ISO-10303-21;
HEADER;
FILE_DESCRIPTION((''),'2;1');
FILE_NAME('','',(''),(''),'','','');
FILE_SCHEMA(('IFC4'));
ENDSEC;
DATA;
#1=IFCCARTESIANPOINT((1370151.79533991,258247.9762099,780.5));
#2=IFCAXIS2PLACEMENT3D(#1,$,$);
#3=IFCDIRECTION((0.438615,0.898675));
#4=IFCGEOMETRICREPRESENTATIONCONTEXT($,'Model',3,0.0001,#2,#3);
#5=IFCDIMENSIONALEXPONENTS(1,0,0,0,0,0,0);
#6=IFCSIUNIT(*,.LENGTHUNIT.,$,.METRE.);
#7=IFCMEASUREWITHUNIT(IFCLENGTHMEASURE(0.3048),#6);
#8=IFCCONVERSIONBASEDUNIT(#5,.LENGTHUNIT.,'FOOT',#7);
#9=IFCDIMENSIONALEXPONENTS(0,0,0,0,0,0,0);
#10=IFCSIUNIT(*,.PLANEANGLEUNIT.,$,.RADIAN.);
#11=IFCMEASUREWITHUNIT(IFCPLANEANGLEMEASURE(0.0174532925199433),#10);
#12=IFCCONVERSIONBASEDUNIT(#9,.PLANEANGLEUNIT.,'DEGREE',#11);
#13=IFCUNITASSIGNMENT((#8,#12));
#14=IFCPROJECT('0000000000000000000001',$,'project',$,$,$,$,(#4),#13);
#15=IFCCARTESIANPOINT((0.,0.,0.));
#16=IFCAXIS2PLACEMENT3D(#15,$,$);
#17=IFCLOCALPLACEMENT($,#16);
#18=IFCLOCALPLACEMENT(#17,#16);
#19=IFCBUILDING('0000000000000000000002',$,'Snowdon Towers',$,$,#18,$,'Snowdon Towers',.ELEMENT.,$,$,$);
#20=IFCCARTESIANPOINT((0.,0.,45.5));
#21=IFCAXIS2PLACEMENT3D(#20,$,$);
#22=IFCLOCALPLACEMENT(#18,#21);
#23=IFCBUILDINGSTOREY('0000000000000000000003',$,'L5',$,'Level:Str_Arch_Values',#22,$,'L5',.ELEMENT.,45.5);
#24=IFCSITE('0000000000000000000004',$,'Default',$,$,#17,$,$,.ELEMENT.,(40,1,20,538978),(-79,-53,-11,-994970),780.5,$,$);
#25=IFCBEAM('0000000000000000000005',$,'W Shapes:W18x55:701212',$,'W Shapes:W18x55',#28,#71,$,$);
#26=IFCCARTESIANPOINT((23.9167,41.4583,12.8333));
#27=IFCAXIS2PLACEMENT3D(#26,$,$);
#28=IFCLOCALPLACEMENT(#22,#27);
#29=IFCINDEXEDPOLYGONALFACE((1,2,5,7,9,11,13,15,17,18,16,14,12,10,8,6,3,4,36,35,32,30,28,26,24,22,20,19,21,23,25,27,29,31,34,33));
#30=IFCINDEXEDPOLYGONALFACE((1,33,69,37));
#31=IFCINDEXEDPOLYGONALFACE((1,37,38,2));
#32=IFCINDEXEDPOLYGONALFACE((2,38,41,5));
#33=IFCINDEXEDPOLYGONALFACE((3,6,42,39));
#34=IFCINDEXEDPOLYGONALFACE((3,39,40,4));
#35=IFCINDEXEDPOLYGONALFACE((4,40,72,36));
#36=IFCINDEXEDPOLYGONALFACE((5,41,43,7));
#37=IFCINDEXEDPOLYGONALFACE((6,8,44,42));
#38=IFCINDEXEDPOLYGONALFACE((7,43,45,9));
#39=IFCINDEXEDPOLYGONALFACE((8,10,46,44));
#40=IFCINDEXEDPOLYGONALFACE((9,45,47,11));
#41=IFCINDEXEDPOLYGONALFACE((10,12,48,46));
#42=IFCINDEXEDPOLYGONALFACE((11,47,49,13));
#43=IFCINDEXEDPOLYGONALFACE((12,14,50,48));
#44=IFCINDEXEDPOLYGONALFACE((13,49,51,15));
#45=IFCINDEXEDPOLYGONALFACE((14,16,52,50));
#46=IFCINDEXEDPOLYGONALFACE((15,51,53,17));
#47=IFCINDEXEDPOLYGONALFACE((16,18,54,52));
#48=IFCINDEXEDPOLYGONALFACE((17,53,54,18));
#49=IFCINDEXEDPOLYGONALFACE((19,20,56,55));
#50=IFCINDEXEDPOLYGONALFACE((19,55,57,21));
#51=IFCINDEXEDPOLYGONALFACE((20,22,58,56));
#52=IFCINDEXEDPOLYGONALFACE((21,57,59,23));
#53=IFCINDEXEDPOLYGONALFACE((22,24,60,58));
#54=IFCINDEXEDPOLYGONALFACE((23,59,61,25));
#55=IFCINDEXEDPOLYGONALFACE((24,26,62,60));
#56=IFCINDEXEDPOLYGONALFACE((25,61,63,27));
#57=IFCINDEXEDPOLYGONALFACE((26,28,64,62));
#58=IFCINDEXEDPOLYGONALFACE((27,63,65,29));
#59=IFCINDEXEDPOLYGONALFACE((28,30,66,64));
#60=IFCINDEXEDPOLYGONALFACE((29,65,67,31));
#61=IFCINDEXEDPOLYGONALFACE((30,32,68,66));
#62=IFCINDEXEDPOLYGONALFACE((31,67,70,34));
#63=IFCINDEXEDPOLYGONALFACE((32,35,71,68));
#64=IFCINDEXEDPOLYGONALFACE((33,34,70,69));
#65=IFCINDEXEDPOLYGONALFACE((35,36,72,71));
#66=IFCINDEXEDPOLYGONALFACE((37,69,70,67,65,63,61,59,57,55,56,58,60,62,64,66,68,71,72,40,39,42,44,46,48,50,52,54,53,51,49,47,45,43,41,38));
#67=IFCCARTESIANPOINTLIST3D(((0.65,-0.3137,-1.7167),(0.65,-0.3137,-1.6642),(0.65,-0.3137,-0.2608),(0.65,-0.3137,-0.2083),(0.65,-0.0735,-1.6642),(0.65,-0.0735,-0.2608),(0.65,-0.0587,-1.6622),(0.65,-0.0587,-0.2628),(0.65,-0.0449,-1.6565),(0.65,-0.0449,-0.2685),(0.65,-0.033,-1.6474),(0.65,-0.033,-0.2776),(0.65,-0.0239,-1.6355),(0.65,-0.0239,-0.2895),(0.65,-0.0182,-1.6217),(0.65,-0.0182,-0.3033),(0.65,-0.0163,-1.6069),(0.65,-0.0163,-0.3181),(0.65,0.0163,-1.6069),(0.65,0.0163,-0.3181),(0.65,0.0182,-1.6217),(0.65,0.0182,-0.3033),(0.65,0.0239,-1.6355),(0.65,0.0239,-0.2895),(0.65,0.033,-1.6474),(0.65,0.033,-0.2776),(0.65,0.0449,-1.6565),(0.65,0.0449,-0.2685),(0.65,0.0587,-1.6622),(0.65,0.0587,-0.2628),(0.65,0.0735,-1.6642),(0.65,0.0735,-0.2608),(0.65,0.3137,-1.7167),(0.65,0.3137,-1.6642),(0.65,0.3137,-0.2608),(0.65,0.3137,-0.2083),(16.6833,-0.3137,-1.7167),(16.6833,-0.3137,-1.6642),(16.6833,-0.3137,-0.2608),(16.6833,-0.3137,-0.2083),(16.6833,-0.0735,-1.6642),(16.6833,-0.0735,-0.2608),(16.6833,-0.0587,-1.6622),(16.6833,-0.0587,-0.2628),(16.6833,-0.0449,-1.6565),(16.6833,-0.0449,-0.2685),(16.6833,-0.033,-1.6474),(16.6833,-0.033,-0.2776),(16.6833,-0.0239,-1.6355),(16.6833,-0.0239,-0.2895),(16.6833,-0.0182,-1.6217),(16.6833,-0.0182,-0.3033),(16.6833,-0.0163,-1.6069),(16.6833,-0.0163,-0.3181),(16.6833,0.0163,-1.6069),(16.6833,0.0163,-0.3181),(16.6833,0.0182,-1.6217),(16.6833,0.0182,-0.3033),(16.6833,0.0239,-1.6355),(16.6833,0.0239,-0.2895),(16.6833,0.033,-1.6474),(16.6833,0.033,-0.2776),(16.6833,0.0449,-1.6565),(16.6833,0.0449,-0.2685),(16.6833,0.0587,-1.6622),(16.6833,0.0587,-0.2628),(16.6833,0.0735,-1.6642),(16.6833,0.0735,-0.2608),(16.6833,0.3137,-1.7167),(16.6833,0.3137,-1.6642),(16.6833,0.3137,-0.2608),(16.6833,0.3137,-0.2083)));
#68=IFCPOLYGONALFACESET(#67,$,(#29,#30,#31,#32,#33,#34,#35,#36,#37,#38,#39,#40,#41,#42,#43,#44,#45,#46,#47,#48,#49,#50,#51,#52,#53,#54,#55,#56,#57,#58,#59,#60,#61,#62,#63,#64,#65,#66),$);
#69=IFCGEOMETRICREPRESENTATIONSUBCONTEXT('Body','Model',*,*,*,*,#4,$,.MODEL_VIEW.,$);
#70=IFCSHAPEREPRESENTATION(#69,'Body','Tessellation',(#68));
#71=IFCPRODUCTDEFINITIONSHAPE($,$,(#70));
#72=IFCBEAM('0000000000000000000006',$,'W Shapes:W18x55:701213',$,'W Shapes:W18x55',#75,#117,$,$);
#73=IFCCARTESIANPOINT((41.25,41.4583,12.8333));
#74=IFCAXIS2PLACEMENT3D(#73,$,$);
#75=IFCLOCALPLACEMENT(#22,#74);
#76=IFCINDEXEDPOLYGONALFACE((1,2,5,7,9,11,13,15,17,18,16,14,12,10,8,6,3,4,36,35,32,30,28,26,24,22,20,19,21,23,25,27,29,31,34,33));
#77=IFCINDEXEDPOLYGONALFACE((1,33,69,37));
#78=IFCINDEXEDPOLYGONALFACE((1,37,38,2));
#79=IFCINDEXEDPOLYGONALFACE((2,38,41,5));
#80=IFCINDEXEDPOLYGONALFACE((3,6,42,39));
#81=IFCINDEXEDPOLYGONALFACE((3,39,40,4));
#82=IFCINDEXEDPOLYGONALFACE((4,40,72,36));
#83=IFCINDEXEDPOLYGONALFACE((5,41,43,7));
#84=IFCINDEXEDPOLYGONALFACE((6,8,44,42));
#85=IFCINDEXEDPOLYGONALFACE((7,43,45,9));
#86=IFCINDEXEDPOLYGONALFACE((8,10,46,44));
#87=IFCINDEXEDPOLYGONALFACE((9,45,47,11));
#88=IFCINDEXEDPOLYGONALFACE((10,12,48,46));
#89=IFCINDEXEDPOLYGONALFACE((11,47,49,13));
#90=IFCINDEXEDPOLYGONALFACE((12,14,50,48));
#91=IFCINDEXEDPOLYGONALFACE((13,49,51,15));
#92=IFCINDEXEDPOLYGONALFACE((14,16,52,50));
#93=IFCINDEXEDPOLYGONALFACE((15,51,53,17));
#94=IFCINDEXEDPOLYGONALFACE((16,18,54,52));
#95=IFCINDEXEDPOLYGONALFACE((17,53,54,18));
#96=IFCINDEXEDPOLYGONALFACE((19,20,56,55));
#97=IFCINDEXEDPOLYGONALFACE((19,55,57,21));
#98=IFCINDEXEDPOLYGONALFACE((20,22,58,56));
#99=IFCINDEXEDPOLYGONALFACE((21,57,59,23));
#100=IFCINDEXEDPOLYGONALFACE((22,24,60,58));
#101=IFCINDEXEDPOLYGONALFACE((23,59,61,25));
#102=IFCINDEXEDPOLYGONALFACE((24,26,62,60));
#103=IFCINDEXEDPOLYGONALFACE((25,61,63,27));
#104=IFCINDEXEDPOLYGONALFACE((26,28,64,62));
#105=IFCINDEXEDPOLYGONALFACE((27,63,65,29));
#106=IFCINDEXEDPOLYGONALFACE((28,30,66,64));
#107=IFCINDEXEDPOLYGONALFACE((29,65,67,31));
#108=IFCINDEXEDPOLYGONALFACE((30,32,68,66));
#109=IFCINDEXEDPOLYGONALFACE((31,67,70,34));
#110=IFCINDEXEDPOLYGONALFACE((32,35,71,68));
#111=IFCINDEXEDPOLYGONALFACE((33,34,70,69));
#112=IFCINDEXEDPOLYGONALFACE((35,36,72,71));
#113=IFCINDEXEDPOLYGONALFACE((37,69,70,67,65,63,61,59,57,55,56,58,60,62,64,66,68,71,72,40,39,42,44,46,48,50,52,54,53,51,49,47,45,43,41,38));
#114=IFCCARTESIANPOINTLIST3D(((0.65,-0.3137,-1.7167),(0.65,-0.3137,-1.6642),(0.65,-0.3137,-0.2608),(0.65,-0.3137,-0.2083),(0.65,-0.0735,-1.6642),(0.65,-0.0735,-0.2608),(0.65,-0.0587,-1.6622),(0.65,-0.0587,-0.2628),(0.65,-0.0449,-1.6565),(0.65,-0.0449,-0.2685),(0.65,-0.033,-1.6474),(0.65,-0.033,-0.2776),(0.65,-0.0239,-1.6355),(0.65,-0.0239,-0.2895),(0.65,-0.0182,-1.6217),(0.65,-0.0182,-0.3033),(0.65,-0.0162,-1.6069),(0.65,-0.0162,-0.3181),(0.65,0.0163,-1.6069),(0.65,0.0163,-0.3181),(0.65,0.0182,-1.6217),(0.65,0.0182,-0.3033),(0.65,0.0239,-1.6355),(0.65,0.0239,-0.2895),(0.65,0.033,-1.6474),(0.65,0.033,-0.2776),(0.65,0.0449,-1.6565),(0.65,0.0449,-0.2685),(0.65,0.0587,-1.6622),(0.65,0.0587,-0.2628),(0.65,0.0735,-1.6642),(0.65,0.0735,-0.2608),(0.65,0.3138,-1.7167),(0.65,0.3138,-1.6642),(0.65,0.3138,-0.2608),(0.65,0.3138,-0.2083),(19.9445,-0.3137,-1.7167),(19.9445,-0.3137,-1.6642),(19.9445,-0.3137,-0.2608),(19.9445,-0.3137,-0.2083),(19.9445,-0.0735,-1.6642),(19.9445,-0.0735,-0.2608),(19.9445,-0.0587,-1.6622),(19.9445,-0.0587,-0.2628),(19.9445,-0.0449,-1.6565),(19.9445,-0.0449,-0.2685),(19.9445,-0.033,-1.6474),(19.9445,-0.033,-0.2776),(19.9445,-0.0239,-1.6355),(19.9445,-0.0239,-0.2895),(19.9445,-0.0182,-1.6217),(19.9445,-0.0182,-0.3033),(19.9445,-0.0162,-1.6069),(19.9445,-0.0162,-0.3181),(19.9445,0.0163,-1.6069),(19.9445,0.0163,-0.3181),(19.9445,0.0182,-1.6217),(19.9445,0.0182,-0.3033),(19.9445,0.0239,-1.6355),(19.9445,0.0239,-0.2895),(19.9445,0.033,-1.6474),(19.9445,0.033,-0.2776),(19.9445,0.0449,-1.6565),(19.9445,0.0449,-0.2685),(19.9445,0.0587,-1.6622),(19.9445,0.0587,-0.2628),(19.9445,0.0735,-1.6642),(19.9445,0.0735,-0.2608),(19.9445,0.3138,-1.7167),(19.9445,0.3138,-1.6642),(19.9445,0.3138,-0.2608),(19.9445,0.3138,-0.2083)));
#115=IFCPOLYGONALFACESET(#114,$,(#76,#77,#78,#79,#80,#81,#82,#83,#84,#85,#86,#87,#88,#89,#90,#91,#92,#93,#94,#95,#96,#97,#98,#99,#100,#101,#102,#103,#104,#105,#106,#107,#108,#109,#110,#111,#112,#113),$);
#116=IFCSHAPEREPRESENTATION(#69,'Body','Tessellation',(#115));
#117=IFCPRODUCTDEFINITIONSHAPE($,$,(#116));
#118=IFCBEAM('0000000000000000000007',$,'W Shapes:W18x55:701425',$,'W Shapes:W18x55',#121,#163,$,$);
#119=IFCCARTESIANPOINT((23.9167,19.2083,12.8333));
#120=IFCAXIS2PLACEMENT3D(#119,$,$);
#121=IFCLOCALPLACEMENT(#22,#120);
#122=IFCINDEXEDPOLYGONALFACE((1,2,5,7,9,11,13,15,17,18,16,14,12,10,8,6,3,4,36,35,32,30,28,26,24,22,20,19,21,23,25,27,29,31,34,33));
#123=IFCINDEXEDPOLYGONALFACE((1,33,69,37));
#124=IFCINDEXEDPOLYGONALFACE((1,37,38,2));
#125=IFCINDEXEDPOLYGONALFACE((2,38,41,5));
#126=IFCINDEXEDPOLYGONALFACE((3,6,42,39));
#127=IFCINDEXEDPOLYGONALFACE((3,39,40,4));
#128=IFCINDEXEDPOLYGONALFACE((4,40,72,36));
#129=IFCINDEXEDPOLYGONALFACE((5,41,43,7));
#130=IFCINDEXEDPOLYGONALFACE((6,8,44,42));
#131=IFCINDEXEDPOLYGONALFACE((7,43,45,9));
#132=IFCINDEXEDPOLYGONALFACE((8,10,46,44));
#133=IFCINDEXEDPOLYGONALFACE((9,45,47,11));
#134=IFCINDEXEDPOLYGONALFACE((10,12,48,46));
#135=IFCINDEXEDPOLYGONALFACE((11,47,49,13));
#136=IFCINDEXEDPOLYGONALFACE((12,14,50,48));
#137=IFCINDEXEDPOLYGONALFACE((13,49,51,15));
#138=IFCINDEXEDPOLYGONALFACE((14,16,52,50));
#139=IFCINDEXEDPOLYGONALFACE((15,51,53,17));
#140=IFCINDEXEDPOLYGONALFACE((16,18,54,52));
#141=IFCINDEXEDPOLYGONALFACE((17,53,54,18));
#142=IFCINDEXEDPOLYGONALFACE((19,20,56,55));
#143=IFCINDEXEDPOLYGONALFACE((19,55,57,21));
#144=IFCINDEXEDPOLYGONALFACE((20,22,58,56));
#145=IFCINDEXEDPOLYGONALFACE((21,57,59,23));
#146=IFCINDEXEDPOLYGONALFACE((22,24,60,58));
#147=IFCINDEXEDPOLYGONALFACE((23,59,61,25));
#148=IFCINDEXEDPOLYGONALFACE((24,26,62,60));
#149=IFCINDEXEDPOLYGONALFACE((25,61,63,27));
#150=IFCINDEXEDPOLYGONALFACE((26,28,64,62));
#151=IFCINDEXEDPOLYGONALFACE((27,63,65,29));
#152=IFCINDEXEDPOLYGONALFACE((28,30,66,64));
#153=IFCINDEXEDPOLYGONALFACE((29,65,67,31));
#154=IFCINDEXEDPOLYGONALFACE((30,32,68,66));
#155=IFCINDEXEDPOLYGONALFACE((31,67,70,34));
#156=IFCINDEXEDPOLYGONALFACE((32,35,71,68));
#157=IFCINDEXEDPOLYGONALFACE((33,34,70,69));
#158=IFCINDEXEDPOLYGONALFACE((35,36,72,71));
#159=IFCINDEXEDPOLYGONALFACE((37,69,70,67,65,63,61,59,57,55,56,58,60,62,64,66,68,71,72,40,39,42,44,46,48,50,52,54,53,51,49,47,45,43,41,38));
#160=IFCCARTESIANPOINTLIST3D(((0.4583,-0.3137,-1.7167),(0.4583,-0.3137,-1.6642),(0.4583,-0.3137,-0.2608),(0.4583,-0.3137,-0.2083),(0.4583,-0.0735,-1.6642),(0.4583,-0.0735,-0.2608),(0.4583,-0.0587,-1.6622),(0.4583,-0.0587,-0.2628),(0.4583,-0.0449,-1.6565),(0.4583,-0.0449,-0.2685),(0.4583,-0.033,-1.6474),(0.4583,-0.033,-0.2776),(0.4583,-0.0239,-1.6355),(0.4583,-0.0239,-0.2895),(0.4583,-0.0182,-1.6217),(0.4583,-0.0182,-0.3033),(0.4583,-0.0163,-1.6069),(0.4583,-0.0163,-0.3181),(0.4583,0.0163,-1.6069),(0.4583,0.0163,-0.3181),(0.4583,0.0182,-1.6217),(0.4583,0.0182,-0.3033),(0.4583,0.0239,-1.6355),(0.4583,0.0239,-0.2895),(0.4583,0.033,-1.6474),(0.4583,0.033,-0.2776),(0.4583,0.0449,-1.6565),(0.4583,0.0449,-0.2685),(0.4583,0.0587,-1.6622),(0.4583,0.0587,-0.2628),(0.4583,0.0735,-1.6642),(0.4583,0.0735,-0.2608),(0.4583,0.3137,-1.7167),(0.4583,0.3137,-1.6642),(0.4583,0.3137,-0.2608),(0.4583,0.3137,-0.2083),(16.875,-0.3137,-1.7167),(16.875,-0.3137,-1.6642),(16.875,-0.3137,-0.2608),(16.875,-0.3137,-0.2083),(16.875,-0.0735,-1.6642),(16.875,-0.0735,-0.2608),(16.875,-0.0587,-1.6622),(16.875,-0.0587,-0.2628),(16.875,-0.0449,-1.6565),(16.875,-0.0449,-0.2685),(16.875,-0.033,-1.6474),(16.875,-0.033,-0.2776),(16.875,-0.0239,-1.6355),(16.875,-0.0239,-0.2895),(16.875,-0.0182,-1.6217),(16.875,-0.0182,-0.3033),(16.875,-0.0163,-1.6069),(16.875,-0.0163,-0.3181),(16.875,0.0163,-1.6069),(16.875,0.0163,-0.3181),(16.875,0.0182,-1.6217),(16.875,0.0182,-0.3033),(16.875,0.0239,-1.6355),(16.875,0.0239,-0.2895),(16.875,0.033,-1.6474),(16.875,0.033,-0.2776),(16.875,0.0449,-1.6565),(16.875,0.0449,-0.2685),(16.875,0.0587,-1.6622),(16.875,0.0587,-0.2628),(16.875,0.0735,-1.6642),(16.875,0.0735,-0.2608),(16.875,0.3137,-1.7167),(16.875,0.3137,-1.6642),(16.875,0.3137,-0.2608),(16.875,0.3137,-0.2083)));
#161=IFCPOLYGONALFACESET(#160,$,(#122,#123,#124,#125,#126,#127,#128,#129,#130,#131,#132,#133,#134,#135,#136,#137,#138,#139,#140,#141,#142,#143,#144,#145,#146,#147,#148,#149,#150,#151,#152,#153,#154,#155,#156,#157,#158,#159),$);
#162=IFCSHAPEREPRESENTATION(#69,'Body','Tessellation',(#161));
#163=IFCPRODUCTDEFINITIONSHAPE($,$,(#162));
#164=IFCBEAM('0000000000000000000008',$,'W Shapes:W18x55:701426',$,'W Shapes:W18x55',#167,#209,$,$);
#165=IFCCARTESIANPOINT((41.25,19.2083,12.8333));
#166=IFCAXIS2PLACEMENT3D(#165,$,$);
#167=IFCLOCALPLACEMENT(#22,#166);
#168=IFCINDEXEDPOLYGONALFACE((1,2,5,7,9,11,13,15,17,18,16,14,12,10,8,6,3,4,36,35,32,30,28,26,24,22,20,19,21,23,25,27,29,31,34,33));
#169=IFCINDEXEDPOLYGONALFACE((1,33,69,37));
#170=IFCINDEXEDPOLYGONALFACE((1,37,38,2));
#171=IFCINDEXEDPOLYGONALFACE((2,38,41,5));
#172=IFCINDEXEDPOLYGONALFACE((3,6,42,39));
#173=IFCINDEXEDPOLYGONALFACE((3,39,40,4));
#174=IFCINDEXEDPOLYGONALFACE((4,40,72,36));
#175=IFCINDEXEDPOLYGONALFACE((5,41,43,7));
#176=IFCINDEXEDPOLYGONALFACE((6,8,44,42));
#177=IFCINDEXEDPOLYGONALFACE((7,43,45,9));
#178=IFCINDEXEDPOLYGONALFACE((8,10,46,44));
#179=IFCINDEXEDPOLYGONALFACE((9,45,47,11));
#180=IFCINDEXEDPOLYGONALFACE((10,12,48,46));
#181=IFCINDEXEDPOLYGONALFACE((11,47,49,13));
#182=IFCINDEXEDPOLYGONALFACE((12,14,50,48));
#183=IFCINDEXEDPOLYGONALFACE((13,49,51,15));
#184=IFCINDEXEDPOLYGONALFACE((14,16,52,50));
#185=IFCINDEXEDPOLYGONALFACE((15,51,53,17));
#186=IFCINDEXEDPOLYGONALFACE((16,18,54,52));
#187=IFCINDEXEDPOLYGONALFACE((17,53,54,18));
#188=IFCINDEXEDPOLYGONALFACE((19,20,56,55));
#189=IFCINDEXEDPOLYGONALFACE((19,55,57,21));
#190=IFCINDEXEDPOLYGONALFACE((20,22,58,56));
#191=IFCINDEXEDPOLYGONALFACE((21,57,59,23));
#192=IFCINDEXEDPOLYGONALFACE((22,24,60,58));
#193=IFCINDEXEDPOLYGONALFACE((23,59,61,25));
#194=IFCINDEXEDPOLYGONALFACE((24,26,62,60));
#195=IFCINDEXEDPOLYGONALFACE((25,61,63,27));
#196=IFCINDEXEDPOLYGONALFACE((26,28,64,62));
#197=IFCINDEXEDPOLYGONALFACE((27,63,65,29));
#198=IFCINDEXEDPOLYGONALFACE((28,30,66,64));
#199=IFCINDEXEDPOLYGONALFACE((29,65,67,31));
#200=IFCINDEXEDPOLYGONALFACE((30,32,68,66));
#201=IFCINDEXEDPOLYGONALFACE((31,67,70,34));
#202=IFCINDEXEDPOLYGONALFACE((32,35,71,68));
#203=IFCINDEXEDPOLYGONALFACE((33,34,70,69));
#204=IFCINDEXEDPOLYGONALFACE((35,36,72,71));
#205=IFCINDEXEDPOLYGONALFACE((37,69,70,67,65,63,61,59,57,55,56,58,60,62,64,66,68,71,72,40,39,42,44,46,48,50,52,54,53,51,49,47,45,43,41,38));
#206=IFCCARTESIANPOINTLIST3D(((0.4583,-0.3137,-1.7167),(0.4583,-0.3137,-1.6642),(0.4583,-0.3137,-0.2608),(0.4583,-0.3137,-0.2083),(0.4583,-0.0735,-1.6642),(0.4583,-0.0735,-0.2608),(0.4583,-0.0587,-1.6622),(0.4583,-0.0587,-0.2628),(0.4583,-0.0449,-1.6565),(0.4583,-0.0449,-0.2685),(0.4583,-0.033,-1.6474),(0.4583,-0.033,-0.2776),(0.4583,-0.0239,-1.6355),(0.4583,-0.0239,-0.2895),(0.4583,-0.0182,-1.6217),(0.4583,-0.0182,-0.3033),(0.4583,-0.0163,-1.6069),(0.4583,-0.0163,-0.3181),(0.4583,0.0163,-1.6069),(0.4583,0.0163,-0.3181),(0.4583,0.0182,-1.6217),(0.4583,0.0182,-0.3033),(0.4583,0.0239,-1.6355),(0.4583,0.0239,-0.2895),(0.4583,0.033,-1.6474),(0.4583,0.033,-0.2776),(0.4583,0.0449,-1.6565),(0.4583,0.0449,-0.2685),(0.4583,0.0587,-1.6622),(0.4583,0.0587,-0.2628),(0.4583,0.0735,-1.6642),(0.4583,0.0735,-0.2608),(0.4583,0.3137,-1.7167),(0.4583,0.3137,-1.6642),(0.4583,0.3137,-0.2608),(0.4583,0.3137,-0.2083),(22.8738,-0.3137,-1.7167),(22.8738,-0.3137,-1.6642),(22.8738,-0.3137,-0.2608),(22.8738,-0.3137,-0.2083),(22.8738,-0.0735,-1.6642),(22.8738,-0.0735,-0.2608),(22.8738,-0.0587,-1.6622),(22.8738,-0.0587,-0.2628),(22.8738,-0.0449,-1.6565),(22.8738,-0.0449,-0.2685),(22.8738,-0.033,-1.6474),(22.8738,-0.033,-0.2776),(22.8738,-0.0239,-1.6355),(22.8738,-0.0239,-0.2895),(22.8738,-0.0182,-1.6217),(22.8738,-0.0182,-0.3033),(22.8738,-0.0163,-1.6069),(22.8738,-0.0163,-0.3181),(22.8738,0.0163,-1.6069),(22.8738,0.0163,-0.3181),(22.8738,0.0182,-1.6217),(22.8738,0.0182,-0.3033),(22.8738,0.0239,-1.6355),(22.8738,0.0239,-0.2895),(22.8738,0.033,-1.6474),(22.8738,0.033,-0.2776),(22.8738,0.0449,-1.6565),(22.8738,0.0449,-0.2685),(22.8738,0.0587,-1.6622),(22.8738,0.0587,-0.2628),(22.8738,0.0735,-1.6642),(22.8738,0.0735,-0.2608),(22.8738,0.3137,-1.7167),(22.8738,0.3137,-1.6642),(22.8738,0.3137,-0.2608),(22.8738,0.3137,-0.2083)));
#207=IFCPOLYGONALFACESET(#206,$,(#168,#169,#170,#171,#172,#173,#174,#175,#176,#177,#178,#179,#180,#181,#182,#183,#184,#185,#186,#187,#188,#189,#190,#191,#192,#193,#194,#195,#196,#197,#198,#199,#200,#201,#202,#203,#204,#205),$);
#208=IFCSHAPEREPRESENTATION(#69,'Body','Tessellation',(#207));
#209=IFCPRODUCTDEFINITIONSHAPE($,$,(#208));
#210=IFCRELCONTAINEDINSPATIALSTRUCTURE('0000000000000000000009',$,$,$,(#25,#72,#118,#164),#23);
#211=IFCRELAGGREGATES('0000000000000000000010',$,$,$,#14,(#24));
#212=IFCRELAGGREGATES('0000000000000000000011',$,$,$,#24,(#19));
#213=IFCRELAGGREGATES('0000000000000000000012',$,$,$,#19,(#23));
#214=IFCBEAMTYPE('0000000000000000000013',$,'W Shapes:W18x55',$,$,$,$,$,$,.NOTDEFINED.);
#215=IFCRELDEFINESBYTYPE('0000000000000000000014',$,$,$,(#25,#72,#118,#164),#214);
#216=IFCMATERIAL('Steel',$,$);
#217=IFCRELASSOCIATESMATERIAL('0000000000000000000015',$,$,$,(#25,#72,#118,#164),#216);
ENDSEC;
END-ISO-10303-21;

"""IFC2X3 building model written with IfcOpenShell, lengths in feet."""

from ifc_helpers import new_model, entity, si_unit, converted_unit, direction, frame, frame_2d, origin, place, context, subcontext, project, spatial, i_section, extrude, material, type_object, element, save


model = new_model("IFC2X3")

# Units and contexts
model_context = context("Model", 3, precision=0.0001, world=frame((1370151.79533991, 258247.9762099, 780.5)), true_north=direction((0.438615, 0.898675)))
body_context = subcontext(model_context, "Body", "Model", "MODEL_VIEW")
ifc_project = project(units=[converted_unit("LENGTHUNIT", "FOOT", entity("IfcLengthMeasure", 0.3048), si_unit("LENGTHUNIT", "METRE"), dimensions=[1, 0, 0, 0, 0, 0, 0]), converted_unit("PLANEANGLEUNIT", "DEGREE", entity("IfcPlaneAngleMeasure", 0.0174532925199433), si_unit("PLANEANGLEUNIT", "RADIAN"), dimensions=[0, 0, 0, 0, 0, 0, 0])], contexts=[model_context])

# Site, building, storey
site_placement = place(None, origin())
site = spatial("IfcSite", under=ifc_project, at=site_placement, Name="Default", CompositionType="ELEMENT", RefLatitude=(40, 1, 20, 538978), RefLongitude=(-79, -53, -11, -994970), RefElevation=780.5)
building_placement = place(site_placement, origin())
building = spatial("IfcBuilding", under=site, at=building_placement, Name="Snowdon Towers", LongName="Snowdon Towers", CompositionType="ELEMENT")
storey_placement = place(building_placement, frame((0.0, 0.0, 45.5)))
storey = spatial("IfcBuildingStorey", under=building, at=storey_placement, Name="L5", ObjectType="Level:Str_Arch_Values", LongName="L5", CompositionType="ELEMENT", Elevation=45.5)

# Shared definitions
ifc_material = material(Name="Steel")

# Beams
beam_type_1 = type_object("IfcBeamType", Name="W Shapes:W18x55", PredefinedType="NOTDEFINED")
beam_1_placement = place(storey_placement, frame((23.9167, 41.4583, 12.8333)))
element("IfcBeam", 1, at=beam_1_placement, inside=storey, type_object=beam_type_1, material=ifc_material, Name="W Shapes:W18x55:701212", ObjectType="W Shapes:W18x55", context=body_context, shape_type="SweptSolid", body=[
    extrude(i_section(OverallWidth=0.6275, OverallDepth=1.5083, WebThickness=0.0325, FlangeThickness=0.0525, FilletRadius=0.0573, at=frame_2d((0.0, 0.0), x_axis=(0.0, 1.0))), frame((0.65, 0.0, -0.9625), z_axis=(1.0, 0.0, 0.0), x_axis=(0.0, 0.0, -1.0)), (0.0, 0.0, 1.0), 16.0333),
])
beam_2_placement = place(storey_placement, frame((41.25, 41.4583, 12.8333)))
element("IfcBeam", 2, at=beam_2_placement, inside=storey, type_object=beam_type_1, material=ifc_material, Name="W Shapes:W18x55:701213", ObjectType="W Shapes:W18x55", context=body_context, shape_type="SweptSolid", body=[
    extrude(i_section(OverallWidth=0.6275, OverallDepth=1.5083, WebThickness=0.0325, FlangeThickness=0.0525, FilletRadius=0.0573, at=frame_2d((0.0, 0.0), x_axis=(0.0, 1.0))), frame((0.65, 0.0, -0.9625), z_axis=(1.0, 0.0, 0.0), x_axis=(0.0, 0.0, -1.0)), (0.0, 0.0, 1.0), 19.2945),
])
beam_3_placement = place(storey_placement, frame((23.9167, 19.2083, 12.8333)))
element("IfcBeam", 3, at=beam_3_placement, inside=storey, type_object=beam_type_1, material=ifc_material, Name="W Shapes:W18x55:701425", ObjectType="W Shapes:W18x55", context=body_context, shape_type="SweptSolid", body=[
    extrude(i_section(OverallWidth=0.6275, OverallDepth=1.5083, WebThickness=0.0325, FlangeThickness=0.0525, FilletRadius=0.0573, at=frame_2d((0.0, 0.0), x_axis=(0.0, 1.0))), frame((0.4583, 0.0, -0.9625), z_axis=(1.0, 0.0, 0.0), x_axis=(0.0, 0.0, -1.0)), (0.0, 0.0, 1.0), 16.4167),
])
beam_4_placement = place(storey_placement, frame((41.25, 19.2083, 12.8333)))
element("IfcBeam", 4, at=beam_4_placement, inside=storey, type_object=beam_type_1, material=ifc_material, Name="W Shapes:W18x55:701426", ObjectType="W Shapes:W18x55", context=body_context, shape_type="SweptSolid", body=[
    extrude(i_section(OverallWidth=0.6275, OverallDepth=1.5083, WebThickness=0.0325, FlangeThickness=0.0525, FilletRadius=0.0573, at=frame_2d((0.0, 0.0), x_axis=(0.0, 1.0))), frame((0.4583, 0.0, -0.9625), z_axis=(1.0, 0.0, 0.0), x_axis=(0.0, 0.0, -1.0)), (0.0, 0.0, 1.0), 22.4154),
])

save(model, "model.ifc")
